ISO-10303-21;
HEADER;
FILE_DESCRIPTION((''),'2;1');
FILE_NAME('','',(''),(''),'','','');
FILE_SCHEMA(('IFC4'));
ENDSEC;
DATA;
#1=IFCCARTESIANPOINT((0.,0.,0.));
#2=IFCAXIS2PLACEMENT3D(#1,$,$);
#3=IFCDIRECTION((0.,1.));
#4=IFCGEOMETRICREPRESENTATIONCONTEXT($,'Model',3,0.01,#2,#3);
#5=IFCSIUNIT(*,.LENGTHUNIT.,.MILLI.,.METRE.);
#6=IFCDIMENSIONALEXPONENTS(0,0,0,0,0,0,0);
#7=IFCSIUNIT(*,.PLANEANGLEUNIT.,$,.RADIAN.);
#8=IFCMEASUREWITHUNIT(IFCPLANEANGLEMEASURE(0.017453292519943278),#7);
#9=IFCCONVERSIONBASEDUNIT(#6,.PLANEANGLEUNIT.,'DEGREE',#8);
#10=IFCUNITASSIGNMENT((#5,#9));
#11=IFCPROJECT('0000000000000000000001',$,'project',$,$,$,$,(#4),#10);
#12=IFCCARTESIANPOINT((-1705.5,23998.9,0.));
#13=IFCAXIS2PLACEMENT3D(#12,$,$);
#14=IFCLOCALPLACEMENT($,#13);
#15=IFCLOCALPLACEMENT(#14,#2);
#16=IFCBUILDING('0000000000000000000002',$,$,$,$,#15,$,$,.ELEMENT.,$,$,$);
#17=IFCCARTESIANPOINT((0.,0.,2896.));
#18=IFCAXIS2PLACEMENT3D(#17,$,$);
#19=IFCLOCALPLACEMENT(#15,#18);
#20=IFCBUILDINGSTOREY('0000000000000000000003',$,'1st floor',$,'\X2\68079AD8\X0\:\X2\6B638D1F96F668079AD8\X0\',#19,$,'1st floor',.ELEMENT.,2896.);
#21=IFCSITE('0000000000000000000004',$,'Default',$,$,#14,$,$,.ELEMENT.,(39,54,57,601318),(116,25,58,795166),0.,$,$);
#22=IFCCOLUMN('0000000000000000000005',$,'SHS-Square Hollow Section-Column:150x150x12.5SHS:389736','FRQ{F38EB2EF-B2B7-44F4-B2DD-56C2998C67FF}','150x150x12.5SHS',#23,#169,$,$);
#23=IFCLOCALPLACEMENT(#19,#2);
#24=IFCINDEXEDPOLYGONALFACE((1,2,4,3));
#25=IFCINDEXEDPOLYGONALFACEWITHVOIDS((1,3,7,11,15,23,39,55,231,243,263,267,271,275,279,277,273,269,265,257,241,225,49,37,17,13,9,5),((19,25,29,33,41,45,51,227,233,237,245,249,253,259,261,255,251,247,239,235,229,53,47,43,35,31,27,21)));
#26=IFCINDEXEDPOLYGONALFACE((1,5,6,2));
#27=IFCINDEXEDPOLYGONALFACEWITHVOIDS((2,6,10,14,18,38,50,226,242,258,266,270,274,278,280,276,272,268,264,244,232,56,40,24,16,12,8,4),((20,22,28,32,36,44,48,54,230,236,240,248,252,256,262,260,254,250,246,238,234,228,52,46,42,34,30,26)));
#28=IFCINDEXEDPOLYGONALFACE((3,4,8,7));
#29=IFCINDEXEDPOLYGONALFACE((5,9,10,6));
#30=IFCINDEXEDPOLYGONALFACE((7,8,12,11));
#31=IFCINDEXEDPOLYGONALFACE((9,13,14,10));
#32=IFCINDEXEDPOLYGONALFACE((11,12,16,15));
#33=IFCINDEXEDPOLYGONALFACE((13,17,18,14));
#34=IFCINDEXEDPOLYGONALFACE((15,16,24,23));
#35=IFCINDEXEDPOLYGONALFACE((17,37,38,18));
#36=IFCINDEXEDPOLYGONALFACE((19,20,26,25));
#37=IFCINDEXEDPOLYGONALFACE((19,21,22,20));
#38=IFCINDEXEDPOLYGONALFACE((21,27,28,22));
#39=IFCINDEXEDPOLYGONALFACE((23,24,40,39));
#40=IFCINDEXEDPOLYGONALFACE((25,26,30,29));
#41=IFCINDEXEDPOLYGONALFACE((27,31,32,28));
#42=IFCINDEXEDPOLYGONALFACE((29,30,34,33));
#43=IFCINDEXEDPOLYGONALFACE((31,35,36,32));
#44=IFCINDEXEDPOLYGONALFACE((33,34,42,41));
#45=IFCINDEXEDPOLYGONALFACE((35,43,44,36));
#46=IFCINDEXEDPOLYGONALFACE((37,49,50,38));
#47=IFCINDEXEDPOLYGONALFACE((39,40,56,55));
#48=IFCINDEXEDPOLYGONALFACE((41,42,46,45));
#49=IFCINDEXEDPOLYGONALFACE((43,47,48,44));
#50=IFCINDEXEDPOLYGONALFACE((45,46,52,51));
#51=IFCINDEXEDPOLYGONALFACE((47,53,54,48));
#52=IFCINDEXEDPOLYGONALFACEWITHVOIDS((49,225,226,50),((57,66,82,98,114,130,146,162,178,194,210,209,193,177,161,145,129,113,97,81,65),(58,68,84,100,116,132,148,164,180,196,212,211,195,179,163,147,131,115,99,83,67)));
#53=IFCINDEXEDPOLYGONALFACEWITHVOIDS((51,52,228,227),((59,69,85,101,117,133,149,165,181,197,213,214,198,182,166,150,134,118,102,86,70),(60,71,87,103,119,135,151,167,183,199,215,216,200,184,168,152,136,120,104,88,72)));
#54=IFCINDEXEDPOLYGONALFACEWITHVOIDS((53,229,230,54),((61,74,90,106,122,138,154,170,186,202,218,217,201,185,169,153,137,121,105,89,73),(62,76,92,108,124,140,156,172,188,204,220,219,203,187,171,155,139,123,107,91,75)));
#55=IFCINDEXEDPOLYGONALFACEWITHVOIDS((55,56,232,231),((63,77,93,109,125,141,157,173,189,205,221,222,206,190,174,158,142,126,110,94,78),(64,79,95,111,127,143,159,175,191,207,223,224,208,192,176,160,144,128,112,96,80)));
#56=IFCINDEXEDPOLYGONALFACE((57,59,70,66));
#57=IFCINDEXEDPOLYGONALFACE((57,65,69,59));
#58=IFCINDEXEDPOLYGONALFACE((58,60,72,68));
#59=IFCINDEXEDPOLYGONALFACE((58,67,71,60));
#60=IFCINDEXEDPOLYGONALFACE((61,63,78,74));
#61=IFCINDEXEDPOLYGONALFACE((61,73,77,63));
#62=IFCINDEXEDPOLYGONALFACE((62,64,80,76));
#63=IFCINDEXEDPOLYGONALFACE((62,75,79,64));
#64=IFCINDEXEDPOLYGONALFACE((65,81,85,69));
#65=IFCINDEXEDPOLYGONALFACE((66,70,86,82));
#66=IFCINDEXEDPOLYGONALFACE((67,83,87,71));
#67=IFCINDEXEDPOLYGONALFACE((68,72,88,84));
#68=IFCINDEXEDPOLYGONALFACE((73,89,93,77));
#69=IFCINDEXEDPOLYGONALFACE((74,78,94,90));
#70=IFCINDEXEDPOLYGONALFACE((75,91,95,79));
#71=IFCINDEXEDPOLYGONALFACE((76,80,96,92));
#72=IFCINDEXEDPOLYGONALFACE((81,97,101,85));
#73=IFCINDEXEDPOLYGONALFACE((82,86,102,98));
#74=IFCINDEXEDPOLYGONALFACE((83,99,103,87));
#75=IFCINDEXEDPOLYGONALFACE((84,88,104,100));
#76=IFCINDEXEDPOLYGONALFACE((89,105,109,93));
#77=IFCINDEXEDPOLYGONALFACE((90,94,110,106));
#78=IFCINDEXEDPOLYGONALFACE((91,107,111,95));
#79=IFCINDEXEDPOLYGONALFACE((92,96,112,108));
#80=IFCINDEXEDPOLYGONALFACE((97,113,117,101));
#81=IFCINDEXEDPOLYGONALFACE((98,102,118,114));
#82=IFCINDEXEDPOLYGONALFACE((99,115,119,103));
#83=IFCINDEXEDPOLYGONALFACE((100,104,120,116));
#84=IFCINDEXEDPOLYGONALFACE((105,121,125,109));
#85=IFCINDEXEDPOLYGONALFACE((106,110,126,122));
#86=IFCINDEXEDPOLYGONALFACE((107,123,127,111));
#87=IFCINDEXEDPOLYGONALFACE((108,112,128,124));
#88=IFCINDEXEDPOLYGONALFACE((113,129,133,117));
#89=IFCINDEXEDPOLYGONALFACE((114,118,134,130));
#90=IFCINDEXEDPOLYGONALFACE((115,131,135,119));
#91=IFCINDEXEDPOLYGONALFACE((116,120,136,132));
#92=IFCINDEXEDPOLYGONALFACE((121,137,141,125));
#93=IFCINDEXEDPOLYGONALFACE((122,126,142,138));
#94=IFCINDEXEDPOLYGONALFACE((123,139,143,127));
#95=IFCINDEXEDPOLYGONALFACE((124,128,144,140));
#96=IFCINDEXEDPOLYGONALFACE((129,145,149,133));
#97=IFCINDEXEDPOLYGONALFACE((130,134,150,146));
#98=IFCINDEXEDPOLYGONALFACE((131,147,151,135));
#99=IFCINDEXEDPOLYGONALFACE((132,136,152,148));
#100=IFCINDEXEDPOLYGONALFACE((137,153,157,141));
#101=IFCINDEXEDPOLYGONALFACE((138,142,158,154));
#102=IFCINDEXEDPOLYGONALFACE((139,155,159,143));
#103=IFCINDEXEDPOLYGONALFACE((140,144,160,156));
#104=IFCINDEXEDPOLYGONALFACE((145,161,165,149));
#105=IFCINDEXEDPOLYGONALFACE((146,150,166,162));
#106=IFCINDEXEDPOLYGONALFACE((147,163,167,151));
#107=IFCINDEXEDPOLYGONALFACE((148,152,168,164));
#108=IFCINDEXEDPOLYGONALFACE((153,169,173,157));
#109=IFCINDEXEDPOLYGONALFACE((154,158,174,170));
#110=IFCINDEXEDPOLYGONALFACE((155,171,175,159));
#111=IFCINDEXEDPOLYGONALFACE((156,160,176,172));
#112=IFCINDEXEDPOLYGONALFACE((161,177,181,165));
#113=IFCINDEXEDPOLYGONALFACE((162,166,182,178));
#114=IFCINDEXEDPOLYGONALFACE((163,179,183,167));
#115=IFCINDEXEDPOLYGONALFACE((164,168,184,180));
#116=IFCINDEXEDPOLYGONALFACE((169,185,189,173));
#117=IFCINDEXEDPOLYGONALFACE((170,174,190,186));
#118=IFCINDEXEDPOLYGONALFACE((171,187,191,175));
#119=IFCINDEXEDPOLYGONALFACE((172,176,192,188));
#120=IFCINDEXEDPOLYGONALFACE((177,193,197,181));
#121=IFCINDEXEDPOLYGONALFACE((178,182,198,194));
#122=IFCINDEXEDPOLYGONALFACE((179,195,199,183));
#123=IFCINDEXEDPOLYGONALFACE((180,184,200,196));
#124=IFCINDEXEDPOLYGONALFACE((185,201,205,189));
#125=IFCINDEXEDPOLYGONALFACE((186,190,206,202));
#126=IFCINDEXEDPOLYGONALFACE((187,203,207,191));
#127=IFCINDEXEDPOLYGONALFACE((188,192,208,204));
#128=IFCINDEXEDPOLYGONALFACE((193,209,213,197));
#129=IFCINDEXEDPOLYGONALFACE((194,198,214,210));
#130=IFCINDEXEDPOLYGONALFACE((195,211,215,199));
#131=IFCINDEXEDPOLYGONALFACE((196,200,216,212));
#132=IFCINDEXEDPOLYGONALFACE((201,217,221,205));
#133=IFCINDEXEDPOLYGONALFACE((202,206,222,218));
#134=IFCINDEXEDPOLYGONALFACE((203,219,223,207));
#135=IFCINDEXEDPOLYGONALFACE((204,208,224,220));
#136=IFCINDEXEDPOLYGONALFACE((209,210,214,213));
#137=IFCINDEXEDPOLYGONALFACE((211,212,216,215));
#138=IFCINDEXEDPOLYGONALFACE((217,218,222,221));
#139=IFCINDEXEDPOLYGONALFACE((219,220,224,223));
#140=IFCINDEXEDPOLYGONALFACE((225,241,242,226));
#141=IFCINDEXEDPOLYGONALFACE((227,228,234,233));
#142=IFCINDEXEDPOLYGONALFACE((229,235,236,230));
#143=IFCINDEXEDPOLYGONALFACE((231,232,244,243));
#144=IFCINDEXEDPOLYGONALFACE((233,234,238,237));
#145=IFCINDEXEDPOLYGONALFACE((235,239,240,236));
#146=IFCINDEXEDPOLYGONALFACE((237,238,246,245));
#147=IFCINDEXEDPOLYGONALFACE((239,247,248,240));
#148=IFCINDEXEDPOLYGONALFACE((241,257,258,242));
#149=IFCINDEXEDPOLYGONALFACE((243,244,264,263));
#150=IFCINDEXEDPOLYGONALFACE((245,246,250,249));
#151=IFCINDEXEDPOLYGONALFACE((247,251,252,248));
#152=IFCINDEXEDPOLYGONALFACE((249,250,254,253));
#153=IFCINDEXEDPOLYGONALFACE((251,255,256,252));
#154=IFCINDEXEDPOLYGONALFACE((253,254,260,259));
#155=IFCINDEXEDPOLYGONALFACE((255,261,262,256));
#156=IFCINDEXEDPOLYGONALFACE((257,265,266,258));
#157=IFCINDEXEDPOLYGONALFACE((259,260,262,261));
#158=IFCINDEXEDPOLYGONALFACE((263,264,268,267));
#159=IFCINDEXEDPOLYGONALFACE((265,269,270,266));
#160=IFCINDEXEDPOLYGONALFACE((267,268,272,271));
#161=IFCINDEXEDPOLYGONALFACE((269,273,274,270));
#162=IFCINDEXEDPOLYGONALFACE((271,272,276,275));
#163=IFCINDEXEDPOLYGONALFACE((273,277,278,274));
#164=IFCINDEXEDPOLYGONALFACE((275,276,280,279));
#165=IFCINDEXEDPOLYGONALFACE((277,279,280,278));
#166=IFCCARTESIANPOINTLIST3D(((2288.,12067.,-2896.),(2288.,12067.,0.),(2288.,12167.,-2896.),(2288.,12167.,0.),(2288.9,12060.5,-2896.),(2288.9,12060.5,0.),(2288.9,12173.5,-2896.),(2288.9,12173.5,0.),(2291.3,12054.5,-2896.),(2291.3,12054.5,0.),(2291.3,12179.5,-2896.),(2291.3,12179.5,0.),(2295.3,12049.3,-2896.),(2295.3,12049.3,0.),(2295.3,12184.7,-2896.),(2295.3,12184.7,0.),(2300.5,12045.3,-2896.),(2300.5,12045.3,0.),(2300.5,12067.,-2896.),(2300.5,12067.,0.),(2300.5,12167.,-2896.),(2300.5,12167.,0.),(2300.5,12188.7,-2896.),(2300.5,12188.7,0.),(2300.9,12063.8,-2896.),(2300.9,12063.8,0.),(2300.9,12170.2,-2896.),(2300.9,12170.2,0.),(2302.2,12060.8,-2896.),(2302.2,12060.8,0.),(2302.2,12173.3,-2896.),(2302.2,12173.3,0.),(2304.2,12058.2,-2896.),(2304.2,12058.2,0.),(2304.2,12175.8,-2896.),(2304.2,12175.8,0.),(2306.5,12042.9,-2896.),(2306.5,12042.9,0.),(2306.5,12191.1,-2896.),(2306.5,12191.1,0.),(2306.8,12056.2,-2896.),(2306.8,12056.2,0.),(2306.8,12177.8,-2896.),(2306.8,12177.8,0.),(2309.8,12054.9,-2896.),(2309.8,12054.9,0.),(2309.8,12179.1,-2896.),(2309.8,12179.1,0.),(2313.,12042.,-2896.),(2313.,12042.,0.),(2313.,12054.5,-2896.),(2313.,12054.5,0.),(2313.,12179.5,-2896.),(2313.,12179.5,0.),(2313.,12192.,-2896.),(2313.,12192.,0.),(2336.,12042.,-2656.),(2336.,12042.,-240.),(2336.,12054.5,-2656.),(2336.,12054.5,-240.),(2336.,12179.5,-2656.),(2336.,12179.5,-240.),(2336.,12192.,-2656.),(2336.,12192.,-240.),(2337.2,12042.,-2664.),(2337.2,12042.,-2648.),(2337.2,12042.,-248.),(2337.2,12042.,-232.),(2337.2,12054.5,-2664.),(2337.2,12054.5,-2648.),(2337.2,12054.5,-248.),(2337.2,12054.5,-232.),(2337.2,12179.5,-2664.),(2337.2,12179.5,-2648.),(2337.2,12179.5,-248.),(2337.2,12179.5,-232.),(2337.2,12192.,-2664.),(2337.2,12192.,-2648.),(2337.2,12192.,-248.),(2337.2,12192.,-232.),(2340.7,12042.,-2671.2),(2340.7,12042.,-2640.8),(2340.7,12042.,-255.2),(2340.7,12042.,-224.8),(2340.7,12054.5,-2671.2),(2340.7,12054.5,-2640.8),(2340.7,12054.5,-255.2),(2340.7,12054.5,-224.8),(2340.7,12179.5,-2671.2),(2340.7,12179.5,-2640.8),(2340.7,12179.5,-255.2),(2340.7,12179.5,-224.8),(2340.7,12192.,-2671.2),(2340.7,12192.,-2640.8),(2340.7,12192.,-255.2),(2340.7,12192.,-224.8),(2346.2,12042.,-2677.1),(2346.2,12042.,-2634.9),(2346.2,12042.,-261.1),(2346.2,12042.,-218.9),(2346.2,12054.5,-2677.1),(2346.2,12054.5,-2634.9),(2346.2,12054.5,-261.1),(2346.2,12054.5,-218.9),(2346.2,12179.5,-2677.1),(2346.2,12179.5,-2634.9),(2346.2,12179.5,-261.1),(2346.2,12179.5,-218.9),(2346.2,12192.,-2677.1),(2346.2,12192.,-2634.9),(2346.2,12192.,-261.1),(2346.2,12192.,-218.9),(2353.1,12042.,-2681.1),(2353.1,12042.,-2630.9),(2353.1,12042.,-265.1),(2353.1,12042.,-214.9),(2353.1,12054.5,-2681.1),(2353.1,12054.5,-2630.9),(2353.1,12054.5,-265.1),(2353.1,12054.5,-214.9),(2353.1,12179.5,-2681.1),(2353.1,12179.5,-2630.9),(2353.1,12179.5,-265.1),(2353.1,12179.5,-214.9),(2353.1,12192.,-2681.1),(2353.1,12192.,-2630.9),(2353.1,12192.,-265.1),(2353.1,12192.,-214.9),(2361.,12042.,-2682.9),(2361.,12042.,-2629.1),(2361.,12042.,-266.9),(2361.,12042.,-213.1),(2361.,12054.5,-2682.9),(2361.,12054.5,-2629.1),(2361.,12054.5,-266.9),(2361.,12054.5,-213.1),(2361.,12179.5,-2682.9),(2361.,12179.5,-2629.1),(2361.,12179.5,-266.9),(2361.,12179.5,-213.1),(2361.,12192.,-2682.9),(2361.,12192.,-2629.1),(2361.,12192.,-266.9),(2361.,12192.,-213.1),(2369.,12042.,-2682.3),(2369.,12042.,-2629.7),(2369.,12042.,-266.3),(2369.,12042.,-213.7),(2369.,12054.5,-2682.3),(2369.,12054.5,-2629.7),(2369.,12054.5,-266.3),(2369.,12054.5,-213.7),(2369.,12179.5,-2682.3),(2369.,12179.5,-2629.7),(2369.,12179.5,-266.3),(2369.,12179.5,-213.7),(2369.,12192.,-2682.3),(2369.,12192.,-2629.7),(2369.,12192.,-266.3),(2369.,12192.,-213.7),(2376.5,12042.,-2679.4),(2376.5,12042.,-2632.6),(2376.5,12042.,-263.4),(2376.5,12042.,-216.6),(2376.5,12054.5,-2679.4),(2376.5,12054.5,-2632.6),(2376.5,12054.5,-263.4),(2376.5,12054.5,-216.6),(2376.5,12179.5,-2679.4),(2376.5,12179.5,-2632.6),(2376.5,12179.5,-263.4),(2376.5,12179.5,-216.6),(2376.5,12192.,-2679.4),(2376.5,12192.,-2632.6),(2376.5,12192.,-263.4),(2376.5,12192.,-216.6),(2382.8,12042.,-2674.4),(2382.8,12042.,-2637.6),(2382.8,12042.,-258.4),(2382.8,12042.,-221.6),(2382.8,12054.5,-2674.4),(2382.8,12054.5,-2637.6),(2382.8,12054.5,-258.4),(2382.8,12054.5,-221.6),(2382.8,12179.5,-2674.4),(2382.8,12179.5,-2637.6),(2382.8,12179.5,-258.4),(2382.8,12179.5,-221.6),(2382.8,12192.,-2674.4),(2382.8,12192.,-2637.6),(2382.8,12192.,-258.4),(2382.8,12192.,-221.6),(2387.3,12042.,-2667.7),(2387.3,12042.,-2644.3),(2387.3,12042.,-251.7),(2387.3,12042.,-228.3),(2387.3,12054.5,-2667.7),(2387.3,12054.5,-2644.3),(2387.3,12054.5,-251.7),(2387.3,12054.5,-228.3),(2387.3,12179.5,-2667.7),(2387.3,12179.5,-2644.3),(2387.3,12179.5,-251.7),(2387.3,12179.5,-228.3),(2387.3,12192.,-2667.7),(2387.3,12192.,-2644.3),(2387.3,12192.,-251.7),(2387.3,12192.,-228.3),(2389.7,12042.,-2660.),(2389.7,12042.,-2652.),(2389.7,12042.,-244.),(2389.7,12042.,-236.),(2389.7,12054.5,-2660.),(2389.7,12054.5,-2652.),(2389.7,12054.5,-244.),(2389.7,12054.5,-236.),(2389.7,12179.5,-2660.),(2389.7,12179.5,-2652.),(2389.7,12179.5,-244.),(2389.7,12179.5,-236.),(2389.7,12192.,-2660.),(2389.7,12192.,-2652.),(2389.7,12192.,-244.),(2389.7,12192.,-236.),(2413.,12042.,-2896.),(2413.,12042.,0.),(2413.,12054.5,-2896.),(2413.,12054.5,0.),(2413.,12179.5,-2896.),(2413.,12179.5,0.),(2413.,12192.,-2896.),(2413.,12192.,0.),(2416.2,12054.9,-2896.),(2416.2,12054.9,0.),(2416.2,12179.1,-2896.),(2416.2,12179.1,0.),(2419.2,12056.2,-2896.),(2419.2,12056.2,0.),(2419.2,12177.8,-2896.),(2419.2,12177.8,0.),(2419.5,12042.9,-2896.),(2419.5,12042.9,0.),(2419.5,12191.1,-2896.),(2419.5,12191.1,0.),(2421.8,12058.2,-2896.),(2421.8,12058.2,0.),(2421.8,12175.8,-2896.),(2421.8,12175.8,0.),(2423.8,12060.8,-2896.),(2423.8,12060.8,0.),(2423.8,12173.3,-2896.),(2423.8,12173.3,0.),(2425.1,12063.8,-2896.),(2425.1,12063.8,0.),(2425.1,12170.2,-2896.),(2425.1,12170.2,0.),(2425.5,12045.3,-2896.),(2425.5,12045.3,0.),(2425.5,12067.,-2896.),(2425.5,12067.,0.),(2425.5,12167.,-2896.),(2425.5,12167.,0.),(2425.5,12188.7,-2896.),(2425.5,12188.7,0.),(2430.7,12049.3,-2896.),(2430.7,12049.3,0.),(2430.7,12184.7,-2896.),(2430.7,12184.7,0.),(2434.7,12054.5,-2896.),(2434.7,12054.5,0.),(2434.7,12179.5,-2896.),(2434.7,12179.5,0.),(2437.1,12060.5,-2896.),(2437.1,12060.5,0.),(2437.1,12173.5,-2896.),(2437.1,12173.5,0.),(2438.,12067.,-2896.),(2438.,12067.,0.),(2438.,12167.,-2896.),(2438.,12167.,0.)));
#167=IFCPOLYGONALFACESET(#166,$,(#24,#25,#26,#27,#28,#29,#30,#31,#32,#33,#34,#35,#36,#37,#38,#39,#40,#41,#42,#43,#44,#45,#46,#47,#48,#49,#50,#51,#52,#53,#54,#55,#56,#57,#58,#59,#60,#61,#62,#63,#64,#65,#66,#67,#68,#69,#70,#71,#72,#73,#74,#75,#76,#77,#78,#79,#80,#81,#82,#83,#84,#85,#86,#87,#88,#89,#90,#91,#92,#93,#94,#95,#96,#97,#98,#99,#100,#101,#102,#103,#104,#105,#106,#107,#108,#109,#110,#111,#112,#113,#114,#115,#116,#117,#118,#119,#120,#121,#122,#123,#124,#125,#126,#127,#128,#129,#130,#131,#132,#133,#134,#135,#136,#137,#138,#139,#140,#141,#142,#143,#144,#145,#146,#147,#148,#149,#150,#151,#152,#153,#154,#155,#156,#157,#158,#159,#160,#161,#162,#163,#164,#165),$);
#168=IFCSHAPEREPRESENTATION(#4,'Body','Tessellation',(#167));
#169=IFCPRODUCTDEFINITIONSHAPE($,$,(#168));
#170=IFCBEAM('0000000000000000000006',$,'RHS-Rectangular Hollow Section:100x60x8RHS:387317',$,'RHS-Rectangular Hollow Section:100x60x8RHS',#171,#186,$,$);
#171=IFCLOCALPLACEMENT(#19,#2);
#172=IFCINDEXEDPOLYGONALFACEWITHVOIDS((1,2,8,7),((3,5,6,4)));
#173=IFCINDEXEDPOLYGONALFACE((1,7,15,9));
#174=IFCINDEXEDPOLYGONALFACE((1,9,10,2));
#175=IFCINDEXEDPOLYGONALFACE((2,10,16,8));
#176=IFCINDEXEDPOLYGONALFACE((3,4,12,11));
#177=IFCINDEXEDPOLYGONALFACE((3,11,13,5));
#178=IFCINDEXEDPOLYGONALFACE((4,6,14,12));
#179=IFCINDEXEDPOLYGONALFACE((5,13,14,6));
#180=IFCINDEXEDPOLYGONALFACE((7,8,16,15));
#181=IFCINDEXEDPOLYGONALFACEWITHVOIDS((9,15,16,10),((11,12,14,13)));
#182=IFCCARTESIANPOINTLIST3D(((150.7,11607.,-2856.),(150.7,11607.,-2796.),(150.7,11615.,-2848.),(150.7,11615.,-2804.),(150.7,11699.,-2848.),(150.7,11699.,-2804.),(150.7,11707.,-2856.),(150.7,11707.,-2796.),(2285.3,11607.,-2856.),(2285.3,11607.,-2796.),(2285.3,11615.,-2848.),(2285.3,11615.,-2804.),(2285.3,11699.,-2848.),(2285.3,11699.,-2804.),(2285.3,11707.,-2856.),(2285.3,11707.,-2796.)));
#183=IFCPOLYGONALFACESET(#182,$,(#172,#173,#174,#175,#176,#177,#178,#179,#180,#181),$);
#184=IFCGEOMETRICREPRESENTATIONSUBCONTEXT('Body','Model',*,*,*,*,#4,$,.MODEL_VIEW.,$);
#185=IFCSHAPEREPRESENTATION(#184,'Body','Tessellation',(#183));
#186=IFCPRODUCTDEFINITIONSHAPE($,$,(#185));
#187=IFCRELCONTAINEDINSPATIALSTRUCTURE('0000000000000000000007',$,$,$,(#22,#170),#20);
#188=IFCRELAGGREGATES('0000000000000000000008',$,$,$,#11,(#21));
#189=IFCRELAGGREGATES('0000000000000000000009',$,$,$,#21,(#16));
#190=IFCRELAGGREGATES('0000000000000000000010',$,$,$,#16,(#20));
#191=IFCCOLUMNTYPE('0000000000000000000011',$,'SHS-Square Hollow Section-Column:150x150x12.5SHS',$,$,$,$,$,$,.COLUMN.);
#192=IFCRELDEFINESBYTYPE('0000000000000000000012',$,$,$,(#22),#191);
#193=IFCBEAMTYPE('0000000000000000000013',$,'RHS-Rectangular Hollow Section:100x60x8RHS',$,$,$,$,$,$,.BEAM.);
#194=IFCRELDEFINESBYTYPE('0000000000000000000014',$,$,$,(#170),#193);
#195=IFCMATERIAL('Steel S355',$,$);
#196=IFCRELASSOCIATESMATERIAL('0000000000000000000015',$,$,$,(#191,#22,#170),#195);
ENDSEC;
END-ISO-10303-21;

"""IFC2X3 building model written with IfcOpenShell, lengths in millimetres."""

from ifc_helpers import new_model, entity, si_unit, converted_unit, direction, frame, frame_2d, origin, origin_2d, place, context, subcontext, project, spatial, circle_curve, rectangle, hollow_rectangle, outline, extrude, boolean, material, type_object, element, save


model = new_model("IFC2X3")

# Units and contexts
model_context = context("Model", 3, precision=0.01, world=origin(), true_north=direction((0.0, 1.0)))
body_context = subcontext(model_context, "Body", "Model", "MODEL_VIEW")
ifc_project = project(units=[si_unit("LENGTHUNIT", "METRE", prefix="MILLI"), converted_unit("PLANEANGLEUNIT", "DEGREE", entity("IfcPlaneAngleMeasure", 0.017453292519943278), si_unit("PLANEANGLEUNIT", "RADIAN"), dimensions=[0, 0, 0, 0, 0, 0, 0])], contexts=[model_context])

# Site, building, storey
site_placement = place(None, frame((-1705.5, 23998.9, 0.0)))
site = spatial("IfcSite", under=ifc_project, at=site_placement, Name="Default", CompositionType="ELEMENT", RefLatitude=(39, 54, 57, 601318), RefLongitude=(116, 25, 58, 795166), RefElevation=0.0)
building_placement = place(site_placement, origin())
building = spatial("IfcBuilding", under=site, at=building_placement, CompositionType="ELEMENT")
storey_placement = place(building_placement, frame((0.0, 0.0, 2896.0)))
storey = spatial("IfcBuildingStorey", under=building, at=storey_placement, Name="1st floor", ObjectType="标高:正负零标高", LongName="1st floor", CompositionType="ELEMENT", Elevation=2896.0)

# Shared definitions
ifc_material_1 = material(Name="Steel S355")

# Column, openings
column_type_1 = type_object("IfcColumnType", Name="SHS-Square Hollow Section-Column:150x150x12.5SHS", PredefinedType="COLUMN", material=ifc_material_1)
column_1_placement = place(storey_placement, frame((2363.0, 12117.0, 0.0), z_axis=(0.0, 0.0, 1.0), x_axis=(0.0, -1.0, 0.0)))
column_1 = element("IfcColumn", 1, at=column_1_placement, inside=storey, type_object=column_type_1, material=ifc_material_1, Name="SHS-Square Hollow Section-Column:150x150x12.5SHS:389736", Description="FRQ{F38EB2EF-B2B7-44F4-B2DD-56C2998C67FF}", ObjectType="150x150x12.5SHS", context=model_context, shape_type="SweptSolid", body=[
    extrude(hollow_rectangle(XDim=150.0, YDim=150.0, WallThickness=12.5, InnerFilletRadius=12.5, OuterFilletRadius=25.0, at=origin_2d()), origin(), (0.0, 0.0, -1.0), 2896.0),
])
opening_1_placement = place(column_1_placement, frame((175.1, 0.0, 0.0), z_axis=(-1.0, 0.0, 0.0), x_axis=(0.0, -1.0, 0.0)))
element("IfcOpeningElement", 2, at=opening_1_placement, cuts=column_1, ObjectType="Opening", context=model_context, shape_type="SweptSolid", body=[
    extrude(outline(circle_curve(frame_2d((0.0, -240.0), x_axis=(1.0, 0.0)), 27.0)), origin(), (0.0, 0.0, 1.0), 350.2),
])
opening_2_placement = place(column_1_placement, frame((175.1, 0.0, -2896.0), z_axis=(-1.0, 0.0, 0.0), x_axis=(0.0, -1.0, 0.0)))
element("IfcOpeningElement", 3, at=opening_2_placement, cuts=column_1, ObjectType="Opening", context=model_context, shape_type="SweptSolid", body=[
    extrude(outline(circle_curve(frame_2d((0.0, 240.0), x_axis=(1.0, 0.0)), 27.0)), origin(), (0.0, 0.0, 1.0), 350.2),
])

# Beam
beam_type_1 = type_object("IfcBeamType", Name="RHS-Rectangular Hollow Section:100x60x8RHS", PredefinedType="BEAM")
beam_1_placement = place(storey_placement, frame((150.7, 11707.0, -2826.0)))
element("IfcBeam", 4, at=beam_1_placement, inside=storey, type_object=beam_type_1, material=ifc_material_1, Name="RHS-Rectangular Hollow Section:100x60x8RHS:387317", ObjectType="RHS-Rectangular Hollow Section:100x60x8RHS", context=body_context, shape_type="SweptSolid", body=[
    boolean("DIFFERENCE", extrude(rectangle(XDim=60.0, YDim=100.0, at=frame_2d((0.0, 0.0), x_axis=(1.0, 0.0))), frame((0.0, -50.0, 0.0), z_axis=(1.0, 0.0, 0.0), x_axis=(0.0, 0.0, -1.0)), (0.0, 0.0, 1.0), 2134.6), extrude(rectangle(XDim=44.0, YDim=84.0, at=frame_2d((0.0, 0.0), x_axis=(0.0, 1.0))), frame((2134.6, -50.0, 0.0), z_axis=(-1.0, 0.0, 0.0), x_axis=(0.0, 1.0, 0.0)), (0.0, 0.0, 1.0), 2134.6)),
])

save(model, "model.ifc")
